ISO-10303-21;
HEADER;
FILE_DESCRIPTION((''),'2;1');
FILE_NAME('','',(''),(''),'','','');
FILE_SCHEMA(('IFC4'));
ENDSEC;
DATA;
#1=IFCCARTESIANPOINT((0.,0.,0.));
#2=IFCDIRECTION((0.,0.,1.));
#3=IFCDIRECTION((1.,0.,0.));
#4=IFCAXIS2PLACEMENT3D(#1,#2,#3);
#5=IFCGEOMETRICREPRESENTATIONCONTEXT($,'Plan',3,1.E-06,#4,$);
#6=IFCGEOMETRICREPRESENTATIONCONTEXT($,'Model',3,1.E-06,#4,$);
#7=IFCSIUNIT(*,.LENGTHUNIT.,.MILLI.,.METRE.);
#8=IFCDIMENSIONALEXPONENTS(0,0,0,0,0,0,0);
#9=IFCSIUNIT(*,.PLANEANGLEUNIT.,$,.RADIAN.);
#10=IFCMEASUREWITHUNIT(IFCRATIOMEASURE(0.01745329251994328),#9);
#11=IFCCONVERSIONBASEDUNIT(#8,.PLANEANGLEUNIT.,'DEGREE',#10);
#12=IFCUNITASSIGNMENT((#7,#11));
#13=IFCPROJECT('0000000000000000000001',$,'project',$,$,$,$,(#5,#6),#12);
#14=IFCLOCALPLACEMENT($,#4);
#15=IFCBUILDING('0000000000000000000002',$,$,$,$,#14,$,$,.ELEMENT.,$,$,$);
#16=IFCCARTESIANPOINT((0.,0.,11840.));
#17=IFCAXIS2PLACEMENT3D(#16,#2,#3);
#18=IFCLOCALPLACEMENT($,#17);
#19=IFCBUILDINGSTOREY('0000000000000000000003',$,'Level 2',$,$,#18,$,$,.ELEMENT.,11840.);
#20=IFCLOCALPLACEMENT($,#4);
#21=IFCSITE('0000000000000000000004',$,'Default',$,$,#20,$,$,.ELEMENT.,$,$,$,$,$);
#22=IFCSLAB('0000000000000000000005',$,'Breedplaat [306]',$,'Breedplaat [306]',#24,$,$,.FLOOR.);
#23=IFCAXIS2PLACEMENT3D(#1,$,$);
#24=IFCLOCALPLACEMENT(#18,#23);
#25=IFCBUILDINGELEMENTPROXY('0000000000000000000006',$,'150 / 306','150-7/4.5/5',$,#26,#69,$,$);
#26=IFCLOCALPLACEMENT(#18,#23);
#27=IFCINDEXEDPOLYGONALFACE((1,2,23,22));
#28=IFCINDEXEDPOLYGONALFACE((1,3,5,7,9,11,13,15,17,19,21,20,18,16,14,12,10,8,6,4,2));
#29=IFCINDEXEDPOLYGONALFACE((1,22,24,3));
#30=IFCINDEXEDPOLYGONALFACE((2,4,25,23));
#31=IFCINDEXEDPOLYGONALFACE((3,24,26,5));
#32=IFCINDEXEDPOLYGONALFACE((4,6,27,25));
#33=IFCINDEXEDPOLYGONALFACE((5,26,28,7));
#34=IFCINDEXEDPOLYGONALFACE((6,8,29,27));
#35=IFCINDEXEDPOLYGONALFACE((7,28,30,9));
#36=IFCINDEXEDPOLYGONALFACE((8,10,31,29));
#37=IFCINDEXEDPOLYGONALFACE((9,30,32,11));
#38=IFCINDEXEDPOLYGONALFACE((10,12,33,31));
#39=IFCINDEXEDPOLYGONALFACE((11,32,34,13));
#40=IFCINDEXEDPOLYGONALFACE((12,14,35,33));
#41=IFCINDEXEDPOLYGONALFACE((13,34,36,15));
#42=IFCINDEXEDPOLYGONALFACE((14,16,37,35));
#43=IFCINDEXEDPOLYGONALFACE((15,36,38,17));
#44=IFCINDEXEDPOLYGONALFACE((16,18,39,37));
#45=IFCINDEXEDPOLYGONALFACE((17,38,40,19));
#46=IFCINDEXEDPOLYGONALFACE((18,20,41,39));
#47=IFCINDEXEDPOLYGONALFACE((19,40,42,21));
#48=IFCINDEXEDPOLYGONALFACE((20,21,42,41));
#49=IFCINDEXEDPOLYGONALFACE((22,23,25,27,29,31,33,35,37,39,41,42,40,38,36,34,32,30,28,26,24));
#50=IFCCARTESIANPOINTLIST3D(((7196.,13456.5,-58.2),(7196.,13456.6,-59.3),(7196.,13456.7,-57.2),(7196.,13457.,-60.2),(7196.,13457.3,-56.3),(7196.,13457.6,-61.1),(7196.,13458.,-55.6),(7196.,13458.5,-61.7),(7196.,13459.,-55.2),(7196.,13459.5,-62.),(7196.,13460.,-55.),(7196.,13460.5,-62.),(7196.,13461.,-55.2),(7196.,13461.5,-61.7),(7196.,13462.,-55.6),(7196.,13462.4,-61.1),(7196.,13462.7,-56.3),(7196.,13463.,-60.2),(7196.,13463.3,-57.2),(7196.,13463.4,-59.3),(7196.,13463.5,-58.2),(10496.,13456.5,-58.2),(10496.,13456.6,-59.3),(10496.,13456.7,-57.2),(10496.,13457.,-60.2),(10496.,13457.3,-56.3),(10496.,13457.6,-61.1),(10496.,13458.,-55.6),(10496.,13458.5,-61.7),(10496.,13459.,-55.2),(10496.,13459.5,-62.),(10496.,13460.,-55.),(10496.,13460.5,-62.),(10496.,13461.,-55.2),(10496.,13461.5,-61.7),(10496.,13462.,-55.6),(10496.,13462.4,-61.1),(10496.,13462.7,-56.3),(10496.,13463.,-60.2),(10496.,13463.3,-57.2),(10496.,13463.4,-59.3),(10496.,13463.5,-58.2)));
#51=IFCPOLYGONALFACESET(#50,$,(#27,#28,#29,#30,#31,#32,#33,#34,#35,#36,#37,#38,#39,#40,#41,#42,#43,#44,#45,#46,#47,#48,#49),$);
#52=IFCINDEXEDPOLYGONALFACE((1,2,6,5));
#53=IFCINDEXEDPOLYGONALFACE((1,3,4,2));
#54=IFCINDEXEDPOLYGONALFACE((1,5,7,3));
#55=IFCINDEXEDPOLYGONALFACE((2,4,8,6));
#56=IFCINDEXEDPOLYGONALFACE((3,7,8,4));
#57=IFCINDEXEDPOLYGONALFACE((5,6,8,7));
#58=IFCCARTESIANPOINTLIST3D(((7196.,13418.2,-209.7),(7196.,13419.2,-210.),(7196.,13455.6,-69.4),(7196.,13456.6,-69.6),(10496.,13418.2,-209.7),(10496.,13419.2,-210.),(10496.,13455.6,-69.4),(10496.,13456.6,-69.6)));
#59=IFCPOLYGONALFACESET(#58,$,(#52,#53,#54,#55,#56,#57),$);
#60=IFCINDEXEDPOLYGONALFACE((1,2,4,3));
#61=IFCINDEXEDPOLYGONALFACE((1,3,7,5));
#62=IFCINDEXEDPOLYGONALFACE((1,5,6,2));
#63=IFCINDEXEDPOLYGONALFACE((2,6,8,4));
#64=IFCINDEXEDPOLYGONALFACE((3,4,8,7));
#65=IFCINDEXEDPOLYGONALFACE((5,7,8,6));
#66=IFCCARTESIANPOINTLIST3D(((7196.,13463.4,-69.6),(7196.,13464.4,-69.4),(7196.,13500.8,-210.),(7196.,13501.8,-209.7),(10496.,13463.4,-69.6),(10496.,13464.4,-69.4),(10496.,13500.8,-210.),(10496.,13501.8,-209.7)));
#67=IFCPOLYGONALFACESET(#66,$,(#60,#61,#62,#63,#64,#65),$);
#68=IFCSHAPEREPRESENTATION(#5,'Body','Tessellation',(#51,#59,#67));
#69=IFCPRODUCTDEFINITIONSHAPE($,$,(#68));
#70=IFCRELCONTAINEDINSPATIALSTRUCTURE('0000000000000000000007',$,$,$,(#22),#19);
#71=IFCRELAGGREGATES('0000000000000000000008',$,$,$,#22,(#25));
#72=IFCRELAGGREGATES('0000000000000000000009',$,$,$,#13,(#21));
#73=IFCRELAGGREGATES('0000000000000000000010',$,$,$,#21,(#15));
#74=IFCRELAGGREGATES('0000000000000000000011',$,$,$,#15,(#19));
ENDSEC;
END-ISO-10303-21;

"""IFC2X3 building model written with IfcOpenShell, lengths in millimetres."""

from ifc_helpers import new_model, entity, si_unit, converted_unit, frame, origin_with_axes, origin_2d_with_axis, place, context, project, spatial, rectangle, circle, extrude, element, aggregate, save


model = new_model("IFC2X3")

# Units and contexts
plan_context = context("Plan", 3, precision=1e-06, world=origin_with_axes())
model_context = context("Model", 3, precision=1e-06, world=origin_with_axes())
ifc_project = project(units=[si_unit("LENGTHUNIT", "METRE", prefix="MILLI"), converted_unit("PLANEANGLEUNIT", "DEGREE", entity("IfcRatioMeasure", 0.01745329251994328), si_unit("PLANEANGLEUNIT", "RADIAN"), dimensions=[0, 0, 0, 0, 0, 0, 0])], contexts=[plan_context, model_context])

# Site, building, storey
site_placement = place(None, origin_with_axes())
site = spatial("IfcSite", under=ifc_project, at=site_placement, Name="Default", CompositionType="ELEMENT")
building_placement = place(None, origin_with_axes())
building = spatial("IfcBuilding", under=site, at=building_placement, CompositionType="ELEMENT")
storey_placement = place(None, frame((0.0, 0.0, 11840.0), z_axis=(0.0, 0.0, 1.0), x_axis=(1.0, 0.0, 0.0)))
storey = spatial("IfcBuildingStorey", under=building, at=storey_placement, Name="Level 2", CompositionType="ELEMENT", Elevation=11840.0)

# Slab, building element proxy
slab_1_placement = place(None, frame((7160.0, 12692.0, 11620.0), z_axis=(0.0, 0.0, 1.0), x_axis=(1.0, 0.0, 0.0)))
slab_1 = element("IfcSlab", 1, at=slab_1_placement, inside=storey, Name="Breedplaat [306]", ObjectType="Breedplaat [306]", PredefinedType="FLOOR")
proxy_1_placement = place(slab_1_placement, frame((36.0, 768.0, 15.0), z_axis=(0.0, 0.0, 1.0), x_axis=(1.0, 0.0, 0.0)))
proxy_1 = element("IfcBuildingElementProxy", 2, at=proxy_1_placement, Name="150 / 306", Description="150-7/4.5/5", context=plan_context, shape_type="SweptSolid", body=[
    extrude(circle(Radius=3.5, at=origin_2d_with_axis()), frame((0.0, 0.0, 146.5), z_axis=(1.0, 0.0, 0.0), x_axis=(0.0, 0.0, 1.0)), (0.0, 0.0, 1.0), 3300.0),
    extrude(rectangle(XDim=145.2, YDim=1.0, at=origin_2d_with_axis()), frame((0.0, -22.6, 65.3), z_axis=(1.0, 0.0, 0.0), x_axis=(0.0, 0.257663, 0.966235)), (0.0, 0.0, 1.0), 3300.0),
    extrude(rectangle(XDim=145.2, YDim=1.0, at=origin_2d_with_axis()), frame((0.0, 22.6, 65.3), z_axis=(1.0, 0.0, 0.0), x_axis=(0.0, -0.257663, 0.966235)), (0.0, 0.0, 1.0), 3300.0),
])
aggregate(slab_1, [proxy_1])

save(model, "model.ifc")
